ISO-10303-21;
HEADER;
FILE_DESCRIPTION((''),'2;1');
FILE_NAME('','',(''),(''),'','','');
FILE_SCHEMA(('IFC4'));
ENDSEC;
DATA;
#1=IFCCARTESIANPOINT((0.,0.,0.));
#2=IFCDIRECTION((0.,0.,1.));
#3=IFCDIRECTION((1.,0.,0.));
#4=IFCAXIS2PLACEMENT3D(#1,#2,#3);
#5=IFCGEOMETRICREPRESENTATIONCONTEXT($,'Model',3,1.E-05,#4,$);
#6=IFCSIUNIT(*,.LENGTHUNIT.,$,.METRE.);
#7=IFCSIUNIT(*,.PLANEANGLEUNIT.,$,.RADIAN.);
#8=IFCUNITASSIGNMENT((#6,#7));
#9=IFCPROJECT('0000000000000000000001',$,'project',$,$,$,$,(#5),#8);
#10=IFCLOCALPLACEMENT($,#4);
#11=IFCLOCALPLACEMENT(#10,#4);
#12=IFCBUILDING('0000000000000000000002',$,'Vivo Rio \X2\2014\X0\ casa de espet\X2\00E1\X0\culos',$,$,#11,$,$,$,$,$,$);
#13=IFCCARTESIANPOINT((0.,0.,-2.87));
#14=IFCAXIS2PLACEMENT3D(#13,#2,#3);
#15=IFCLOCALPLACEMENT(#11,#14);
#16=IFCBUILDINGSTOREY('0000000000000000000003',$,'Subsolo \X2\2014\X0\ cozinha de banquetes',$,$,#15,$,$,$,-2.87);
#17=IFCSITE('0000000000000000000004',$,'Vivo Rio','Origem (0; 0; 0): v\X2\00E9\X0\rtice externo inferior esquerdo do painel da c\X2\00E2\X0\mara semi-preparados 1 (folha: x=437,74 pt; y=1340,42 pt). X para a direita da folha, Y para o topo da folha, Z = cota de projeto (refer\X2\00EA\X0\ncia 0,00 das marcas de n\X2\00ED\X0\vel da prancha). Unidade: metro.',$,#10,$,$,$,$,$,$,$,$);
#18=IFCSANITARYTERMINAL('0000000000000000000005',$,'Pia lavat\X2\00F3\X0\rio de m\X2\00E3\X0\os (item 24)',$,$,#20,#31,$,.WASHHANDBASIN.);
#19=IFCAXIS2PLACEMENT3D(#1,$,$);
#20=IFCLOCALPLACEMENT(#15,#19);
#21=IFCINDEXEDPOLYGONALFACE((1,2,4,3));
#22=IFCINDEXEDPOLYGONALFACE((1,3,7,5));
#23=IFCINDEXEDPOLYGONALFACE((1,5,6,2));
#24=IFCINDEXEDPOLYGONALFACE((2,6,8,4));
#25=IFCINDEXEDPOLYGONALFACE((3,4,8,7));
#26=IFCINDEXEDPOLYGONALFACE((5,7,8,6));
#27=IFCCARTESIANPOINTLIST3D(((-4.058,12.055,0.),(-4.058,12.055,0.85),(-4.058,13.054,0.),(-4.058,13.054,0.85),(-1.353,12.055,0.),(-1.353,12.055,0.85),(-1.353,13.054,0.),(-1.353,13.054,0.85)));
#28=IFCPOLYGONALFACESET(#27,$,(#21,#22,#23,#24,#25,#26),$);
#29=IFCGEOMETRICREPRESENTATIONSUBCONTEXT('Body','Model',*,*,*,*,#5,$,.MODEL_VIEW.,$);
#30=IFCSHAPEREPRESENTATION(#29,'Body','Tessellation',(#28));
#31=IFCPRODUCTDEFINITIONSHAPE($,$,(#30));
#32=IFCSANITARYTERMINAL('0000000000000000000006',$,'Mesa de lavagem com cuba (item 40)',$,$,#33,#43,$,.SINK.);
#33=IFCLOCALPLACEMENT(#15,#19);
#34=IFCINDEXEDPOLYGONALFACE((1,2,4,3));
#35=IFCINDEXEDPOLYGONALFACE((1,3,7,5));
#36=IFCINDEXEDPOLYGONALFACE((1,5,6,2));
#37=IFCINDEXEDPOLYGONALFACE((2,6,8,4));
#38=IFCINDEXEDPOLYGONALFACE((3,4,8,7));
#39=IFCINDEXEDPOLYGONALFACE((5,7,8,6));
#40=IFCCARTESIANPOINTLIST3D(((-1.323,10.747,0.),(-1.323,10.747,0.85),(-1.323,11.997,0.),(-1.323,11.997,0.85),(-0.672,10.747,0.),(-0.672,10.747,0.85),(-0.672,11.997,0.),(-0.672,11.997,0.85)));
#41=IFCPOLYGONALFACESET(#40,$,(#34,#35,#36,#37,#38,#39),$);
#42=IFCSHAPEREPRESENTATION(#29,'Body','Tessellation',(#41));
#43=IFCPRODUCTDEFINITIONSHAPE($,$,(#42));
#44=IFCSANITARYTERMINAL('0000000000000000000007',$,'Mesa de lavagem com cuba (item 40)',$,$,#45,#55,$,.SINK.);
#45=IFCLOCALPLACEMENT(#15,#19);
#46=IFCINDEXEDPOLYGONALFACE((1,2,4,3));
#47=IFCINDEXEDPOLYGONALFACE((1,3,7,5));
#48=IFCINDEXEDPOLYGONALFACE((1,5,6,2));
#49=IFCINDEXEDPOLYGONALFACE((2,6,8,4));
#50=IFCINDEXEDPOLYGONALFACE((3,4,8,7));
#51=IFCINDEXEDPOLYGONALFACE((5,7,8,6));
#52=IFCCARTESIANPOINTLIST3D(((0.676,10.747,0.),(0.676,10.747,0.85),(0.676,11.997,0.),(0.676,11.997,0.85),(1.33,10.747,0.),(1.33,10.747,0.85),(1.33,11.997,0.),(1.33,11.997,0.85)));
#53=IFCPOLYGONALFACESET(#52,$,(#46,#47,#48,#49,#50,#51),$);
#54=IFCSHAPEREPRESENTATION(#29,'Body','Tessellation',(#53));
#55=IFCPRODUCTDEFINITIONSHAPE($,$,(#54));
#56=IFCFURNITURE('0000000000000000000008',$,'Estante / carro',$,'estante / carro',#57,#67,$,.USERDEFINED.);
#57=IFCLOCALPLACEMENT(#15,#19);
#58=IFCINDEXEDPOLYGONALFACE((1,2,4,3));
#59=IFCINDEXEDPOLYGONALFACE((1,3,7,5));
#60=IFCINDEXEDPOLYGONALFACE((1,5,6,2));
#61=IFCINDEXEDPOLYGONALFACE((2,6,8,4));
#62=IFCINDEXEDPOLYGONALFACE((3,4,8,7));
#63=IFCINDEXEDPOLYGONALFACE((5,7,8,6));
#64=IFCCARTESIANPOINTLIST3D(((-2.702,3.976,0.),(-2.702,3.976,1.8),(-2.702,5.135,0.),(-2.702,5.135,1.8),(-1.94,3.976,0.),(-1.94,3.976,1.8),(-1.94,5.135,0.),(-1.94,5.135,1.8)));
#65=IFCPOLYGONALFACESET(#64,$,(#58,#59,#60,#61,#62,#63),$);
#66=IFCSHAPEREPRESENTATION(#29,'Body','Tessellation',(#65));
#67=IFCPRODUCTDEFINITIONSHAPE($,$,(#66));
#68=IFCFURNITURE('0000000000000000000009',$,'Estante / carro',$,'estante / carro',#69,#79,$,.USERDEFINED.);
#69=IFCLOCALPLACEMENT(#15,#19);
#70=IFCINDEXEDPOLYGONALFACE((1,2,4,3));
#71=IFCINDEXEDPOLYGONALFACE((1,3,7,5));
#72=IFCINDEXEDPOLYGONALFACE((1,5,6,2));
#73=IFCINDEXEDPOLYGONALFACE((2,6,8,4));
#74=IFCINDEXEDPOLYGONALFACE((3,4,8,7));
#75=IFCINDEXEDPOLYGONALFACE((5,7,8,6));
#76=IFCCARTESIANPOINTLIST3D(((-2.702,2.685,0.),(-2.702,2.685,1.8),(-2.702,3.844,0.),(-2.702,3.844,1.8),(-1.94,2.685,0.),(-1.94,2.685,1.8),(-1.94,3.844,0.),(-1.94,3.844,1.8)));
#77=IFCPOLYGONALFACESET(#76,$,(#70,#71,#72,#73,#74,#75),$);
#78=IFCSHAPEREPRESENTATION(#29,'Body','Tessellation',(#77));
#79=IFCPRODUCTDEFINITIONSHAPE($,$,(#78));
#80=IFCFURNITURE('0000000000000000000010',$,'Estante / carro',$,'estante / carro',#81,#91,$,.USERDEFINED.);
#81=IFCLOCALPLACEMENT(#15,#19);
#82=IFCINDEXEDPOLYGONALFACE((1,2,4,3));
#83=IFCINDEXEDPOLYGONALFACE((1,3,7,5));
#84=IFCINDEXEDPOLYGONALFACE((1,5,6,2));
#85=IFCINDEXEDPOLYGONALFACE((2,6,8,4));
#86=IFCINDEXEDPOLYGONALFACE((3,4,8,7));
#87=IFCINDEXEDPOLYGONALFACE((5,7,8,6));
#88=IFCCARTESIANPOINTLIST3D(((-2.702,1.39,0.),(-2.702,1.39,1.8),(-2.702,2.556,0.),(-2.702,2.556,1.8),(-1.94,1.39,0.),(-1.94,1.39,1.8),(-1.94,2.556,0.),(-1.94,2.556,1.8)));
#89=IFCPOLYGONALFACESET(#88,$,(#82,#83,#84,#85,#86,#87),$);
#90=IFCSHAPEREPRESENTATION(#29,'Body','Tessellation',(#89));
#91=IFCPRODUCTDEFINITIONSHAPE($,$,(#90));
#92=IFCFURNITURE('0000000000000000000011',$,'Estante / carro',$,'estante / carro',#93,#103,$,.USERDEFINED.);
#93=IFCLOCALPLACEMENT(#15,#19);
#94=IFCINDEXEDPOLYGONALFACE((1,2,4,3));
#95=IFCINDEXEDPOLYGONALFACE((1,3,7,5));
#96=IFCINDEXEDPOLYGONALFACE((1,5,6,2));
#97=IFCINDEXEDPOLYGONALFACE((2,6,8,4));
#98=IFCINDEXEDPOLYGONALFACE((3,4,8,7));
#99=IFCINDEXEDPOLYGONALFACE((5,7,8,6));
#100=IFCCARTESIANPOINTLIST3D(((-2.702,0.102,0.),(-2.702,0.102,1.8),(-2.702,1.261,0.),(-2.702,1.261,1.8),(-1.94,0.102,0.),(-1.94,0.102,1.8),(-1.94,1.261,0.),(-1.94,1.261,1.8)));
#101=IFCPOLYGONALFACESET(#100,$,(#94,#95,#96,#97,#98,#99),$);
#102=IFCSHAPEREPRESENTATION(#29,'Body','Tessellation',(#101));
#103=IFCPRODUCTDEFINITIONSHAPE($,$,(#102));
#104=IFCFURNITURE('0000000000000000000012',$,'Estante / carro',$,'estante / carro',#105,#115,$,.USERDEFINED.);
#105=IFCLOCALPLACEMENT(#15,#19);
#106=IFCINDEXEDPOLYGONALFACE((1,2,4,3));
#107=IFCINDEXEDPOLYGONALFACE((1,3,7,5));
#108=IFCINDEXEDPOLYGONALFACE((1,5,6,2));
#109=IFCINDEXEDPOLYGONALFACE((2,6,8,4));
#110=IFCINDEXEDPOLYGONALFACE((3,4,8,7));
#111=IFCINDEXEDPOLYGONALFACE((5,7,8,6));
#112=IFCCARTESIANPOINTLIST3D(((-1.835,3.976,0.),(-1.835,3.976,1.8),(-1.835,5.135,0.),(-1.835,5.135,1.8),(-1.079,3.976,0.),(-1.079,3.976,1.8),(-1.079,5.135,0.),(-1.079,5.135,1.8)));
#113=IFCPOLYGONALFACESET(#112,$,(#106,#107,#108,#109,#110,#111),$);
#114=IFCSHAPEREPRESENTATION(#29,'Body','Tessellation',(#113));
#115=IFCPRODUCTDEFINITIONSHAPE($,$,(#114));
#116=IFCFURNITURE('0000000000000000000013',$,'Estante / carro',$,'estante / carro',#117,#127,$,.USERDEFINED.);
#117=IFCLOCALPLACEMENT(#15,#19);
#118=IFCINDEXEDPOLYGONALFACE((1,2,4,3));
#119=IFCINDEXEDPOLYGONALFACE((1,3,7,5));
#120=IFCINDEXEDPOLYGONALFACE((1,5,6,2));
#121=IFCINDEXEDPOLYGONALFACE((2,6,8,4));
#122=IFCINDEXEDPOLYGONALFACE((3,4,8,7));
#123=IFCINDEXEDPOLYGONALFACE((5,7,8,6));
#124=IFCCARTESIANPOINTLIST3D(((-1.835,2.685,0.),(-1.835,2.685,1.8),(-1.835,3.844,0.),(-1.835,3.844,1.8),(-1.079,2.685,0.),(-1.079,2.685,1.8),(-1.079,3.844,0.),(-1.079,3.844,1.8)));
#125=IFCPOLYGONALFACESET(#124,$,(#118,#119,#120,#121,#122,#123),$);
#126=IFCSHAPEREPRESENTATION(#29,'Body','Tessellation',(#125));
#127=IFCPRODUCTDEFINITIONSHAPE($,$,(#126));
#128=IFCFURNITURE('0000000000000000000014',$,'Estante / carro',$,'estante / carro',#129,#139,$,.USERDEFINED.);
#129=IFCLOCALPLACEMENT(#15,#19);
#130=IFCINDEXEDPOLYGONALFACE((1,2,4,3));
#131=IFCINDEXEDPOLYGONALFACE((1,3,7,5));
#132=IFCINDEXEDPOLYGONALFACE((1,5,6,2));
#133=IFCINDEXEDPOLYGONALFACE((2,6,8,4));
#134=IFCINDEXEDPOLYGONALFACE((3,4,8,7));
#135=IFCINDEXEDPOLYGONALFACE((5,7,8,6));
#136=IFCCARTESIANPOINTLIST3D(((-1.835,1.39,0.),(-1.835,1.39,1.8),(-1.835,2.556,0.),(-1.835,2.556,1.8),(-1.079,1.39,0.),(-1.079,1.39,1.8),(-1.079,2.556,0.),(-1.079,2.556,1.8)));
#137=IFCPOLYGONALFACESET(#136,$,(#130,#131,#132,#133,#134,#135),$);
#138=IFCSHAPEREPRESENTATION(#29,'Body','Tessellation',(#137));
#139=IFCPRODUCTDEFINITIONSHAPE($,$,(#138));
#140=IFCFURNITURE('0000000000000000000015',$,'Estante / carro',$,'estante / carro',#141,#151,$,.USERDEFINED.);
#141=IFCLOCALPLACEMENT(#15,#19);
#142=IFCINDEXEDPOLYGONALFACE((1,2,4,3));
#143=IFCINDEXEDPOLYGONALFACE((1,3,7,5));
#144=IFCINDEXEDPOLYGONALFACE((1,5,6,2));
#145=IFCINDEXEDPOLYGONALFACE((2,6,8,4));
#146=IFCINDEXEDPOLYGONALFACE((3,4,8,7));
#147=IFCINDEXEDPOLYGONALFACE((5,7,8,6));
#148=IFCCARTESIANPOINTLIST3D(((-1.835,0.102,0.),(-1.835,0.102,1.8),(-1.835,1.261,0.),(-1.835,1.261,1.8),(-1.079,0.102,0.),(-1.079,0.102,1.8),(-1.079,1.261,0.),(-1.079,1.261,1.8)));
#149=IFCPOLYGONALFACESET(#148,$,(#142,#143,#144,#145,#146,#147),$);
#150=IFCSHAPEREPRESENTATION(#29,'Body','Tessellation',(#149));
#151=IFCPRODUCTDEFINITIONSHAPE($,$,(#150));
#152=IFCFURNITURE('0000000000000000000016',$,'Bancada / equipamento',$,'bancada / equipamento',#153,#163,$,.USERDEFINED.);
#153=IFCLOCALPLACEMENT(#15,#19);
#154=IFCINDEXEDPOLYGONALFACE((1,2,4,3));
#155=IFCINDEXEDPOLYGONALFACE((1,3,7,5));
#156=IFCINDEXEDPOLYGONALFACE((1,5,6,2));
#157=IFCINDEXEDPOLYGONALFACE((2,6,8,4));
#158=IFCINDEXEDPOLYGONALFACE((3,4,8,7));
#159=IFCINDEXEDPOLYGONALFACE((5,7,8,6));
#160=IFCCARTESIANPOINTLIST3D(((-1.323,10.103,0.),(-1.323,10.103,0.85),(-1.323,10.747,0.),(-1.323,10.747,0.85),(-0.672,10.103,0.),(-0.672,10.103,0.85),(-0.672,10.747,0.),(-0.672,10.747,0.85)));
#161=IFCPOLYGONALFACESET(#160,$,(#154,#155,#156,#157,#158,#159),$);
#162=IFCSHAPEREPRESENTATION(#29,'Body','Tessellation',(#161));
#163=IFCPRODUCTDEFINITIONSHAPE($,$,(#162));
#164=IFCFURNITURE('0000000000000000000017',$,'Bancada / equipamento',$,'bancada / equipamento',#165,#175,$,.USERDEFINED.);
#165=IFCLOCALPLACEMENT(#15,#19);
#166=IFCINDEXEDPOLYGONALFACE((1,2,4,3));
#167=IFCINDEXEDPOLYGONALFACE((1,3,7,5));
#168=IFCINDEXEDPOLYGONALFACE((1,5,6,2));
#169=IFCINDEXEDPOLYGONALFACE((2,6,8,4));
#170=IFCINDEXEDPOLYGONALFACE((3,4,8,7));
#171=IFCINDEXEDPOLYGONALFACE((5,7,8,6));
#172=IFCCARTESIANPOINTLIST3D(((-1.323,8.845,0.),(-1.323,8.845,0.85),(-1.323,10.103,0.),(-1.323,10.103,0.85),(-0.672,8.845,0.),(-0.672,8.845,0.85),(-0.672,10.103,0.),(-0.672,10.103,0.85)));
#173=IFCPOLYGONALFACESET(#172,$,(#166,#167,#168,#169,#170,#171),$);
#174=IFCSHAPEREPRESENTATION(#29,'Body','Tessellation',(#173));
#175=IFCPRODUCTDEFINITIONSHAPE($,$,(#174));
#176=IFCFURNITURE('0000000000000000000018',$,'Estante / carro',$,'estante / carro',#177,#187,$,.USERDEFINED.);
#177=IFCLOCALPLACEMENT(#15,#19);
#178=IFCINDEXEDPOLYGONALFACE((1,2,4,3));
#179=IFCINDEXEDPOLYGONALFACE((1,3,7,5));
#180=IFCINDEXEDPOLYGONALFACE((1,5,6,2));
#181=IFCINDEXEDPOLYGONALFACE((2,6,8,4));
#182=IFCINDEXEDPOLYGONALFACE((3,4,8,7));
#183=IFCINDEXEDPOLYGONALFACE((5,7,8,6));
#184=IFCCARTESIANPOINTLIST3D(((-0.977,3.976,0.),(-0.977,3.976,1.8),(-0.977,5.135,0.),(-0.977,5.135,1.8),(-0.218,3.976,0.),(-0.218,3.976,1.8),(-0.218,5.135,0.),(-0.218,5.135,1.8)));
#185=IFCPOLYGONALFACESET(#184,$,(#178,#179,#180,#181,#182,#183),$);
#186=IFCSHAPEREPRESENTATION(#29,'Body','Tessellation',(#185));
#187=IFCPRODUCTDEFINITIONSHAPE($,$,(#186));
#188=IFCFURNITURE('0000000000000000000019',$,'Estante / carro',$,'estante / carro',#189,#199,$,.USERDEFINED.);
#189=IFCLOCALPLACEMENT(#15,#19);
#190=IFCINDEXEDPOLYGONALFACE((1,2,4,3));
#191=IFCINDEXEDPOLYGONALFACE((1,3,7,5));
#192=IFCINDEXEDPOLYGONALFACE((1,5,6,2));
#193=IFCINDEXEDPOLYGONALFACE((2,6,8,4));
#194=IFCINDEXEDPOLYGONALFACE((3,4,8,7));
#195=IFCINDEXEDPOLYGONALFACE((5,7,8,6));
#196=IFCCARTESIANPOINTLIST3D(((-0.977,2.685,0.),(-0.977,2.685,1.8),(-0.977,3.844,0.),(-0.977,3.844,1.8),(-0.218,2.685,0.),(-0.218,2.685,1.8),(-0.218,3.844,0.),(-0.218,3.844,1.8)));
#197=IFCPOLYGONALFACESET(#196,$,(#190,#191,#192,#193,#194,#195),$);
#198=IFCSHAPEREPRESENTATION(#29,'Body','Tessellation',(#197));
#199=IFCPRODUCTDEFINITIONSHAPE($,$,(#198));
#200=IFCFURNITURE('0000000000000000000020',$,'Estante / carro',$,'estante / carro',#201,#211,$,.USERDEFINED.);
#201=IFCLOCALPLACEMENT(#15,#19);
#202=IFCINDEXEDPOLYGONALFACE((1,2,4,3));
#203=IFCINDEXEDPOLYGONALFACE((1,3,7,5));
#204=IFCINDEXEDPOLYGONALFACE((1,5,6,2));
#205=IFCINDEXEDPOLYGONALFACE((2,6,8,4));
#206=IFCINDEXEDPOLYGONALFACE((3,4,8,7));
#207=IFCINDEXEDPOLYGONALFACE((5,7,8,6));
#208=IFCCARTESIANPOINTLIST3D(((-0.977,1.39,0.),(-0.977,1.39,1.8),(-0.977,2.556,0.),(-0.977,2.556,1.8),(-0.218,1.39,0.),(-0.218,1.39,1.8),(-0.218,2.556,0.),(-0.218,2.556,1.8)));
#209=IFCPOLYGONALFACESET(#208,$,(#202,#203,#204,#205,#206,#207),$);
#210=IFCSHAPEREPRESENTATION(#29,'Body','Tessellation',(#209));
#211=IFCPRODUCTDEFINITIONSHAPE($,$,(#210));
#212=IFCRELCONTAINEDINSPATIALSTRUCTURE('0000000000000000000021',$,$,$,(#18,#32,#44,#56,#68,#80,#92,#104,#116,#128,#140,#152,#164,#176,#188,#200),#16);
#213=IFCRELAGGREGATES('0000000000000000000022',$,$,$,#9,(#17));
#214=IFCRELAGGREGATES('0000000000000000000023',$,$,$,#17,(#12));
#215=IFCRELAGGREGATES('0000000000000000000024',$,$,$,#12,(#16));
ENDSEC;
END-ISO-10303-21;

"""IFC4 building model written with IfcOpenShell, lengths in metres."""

from ifc_helpers import new_model, si_unit, frame, origin_with_axes, origin_2d, place, context, subcontext, project, spatial, rectangle, extrude, element, save


model = new_model("IFC4")

# Units and contexts
model_context = context("Model", 3, precision=1e-05, world=origin_with_axes())
body_context = subcontext(model_context, "Body", "Model", "MODEL_VIEW")
ifc_project = project(units=[si_unit("LENGTHUNIT", "METRE"), si_unit("PLANEANGLEUNIT", "RADIAN")], contexts=[model_context])

# Site, building, storey
site_placement = place(None, origin_with_axes())
site = spatial("IfcSite", under=ifc_project, at=site_placement, Name="Vivo Rio", Description="Origem (0; 0; 0): vértice externo inferior esquerdo do painel da câmara semi-preparados 1 (folha: x=437,74 pt; y=1340,42 pt). X para a direita da folha, Y para o topo da folha, Z = cota de projeto (referência 0,00 das marcas de nível da prancha). Unidade: metro.")
building_placement = place(site_placement, origin_with_axes())
building = spatial("IfcBuilding", under=site, at=building_placement, Name="Vivo Rio — casa de espetáculos")
storey_placement = place(building_placement, frame((0.0, 0.0, -2.87), z_axis=(0.0, 0.0, 1.0), x_axis=(1.0, 0.0, 0.0)))
storey = spatial("IfcBuildingStorey", under=building, at=storey_placement, Name="Subsolo — cozinha de banquetes", Elevation=-2.87)

# Sanitary terminals
sanitary_terminal_1_placement = place(storey_placement, origin_with_axes())
element("IfcSanitaryTerminal", 1, at=sanitary_terminal_1_placement, inside=storey, Name="Pia lavatório de mãos (item 24)", PredefinedType="WASHHANDBASIN", context=body_context, shape_type="SweptSolid", body=[
    extrude(rectangle(XDim=2.705, YDim=0.999, at=origin_2d()), frame((-2.7055, 12.5545, 0.0), z_axis=(0.0, 0.0, 1.0), x_axis=(1.0, 0.0, 0.0)), (0.0, 0.0, 1.0), 0.85),
])
sanitary_terminal_2_placement = place(storey_placement, origin_with_axes())
element("IfcSanitaryTerminal", 2, at=sanitary_terminal_2_placement, inside=storey, Name="Mesa de lavagem com cuba (item 40)", PredefinedType="SINK", context=body_context, shape_type="SweptSolid", body=[
    extrude(rectangle(XDim=0.651, YDim=1.25, at=origin_2d()), frame((-0.9975, 11.372, 0.0), z_axis=(0.0, 0.0, 1.0), x_axis=(1.0, 0.0, 0.0)), (0.0, 0.0, 1.0), 0.85),
])
sanitary_terminal_3_placement = place(storey_placement, origin_with_axes())
element("IfcSanitaryTerminal", 3, at=sanitary_terminal_3_placement, inside=storey, Name="Mesa de lavagem com cuba (item 40)", PredefinedType="SINK", context=body_context, shape_type="SweptSolid", body=[
    extrude(rectangle(XDim=0.654, YDim=1.25, at=origin_2d()), frame((1.003, 11.372, 0.0), z_axis=(0.0, 0.0, 1.0), x_axis=(1.0, 0.0, 0.0)), (0.0, 0.0, 1.0), 0.85),
])

# Furniture
furniture_1_placement = place(storey_placement, origin_with_axes())
element("IfcFurniture", 4, at=furniture_1_placement, inside=storey, Name="Estante / carro", ObjectType="estante / carro", PredefinedType="USERDEFINED", context=body_context, shape_type="SweptSolid", body=[
    extrude(rectangle(XDim=0.762, YDim=1.159, at=origin_2d()), frame((-2.321, 4.5555, 0.0), z_axis=(0.0, 0.0, 1.0), x_axis=(1.0, 0.0, 0.0)), (0.0, 0.0, 1.0), 1.8),
])
furniture_2_placement = place(storey_placement, origin_with_axes())
element("IfcFurniture", 5, at=furniture_2_placement, inside=storey, Name="Estante / carro", ObjectType="estante / carro", PredefinedType="USERDEFINED", context=body_context, shape_type="SweptSolid", body=[
    extrude(rectangle(XDim=0.762, YDim=1.159, at=origin_2d()), frame((-2.321, 3.2645, 0.0), z_axis=(0.0, 0.0, 1.0), x_axis=(1.0, 0.0, 0.0)), (0.0, 0.0, 1.0), 1.8),
])
furniture_3_placement = place(storey_placement, origin_with_axes())
element("IfcFurniture", 6, at=furniture_3_placement, inside=storey, Name="Estante / carro", ObjectType="estante / carro", PredefinedType="USERDEFINED", context=body_context, shape_type="SweptSolid", body=[
    extrude(rectangle(XDim=0.762, YDim=1.166, at=origin_2d()), frame((-2.321, 1.973, 0.0), z_axis=(0.0, 0.0, 1.0), x_axis=(1.0, 0.0, 0.0)), (0.0, 0.0, 1.0), 1.8),
])
furniture_4_placement = place(storey_placement, origin_with_axes())
element("IfcFurniture", 7, at=furniture_4_placement, inside=storey, Name="Estante / carro", ObjectType="estante / carro", PredefinedType="USERDEFINED", context=body_context, shape_type="SweptSolid", body=[
    extrude(rectangle(XDim=0.762, YDim=1.159, at=origin_2d()), frame((-2.321, 0.6815, 0.0), z_axis=(0.0, 0.0, 1.0), x_axis=(1.0, 0.0, 0.0)), (0.0, 0.0, 1.0), 1.8),
])
furniture_5_placement = place(storey_placement, origin_with_axes())
element("IfcFurniture", 8, at=furniture_5_placement, inside=storey, Name="Estante / carro", ObjectType="estante / carro", PredefinedType="USERDEFINED", context=body_context, shape_type="SweptSolid", body=[
    extrude(rectangle(XDim=0.756, YDim=1.159, at=origin_2d()), frame((-1.457, 4.5555, 0.0), z_axis=(0.0, 0.0, 1.0), x_axis=(1.0, 0.0, 0.0)), (0.0, 0.0, 1.0), 1.8),
])
furniture_6_placement = place(storey_placement, origin_with_axes())
element("IfcFurniture", 9, at=furniture_6_placement, inside=storey, Name="Estante / carro", ObjectType="estante / carro", PredefinedType="USERDEFINED", context=body_context, shape_type="SweptSolid", body=[
    extrude(rectangle(XDim=0.756, YDim=1.159, at=origin_2d()), frame((-1.457, 3.2645, 0.0), z_axis=(0.0, 0.0, 1.0), x_axis=(1.0, 0.0, 0.0)), (0.0, 0.0, 1.0), 1.8),
])
furniture_7_placement = place(storey_placement, origin_with_axes())
element("IfcFurniture", 10, at=furniture_7_placement, inside=storey, Name="Estante / carro", ObjectType="estante / carro", PredefinedType="USERDEFINED", context=body_context, shape_type="SweptSolid", body=[
    extrude(rectangle(XDim=0.756, YDim=1.166, at=origin_2d()), frame((-1.457, 1.973, 0.0), z_axis=(0.0, 0.0, 1.0), x_axis=(1.0, 0.0, 0.0)), (0.0, 0.0, 1.0), 1.8),
])
furniture_8_placement = place(storey_placement, origin_with_axes())
element("IfcFurniture", 11, at=furniture_8_placement, inside=storey, Name="Estante / carro", ObjectType="estante / carro", PredefinedType="USERDEFINED", context=body_context, shape_type="SweptSolid", body=[
    extrude(rectangle(XDim=0.756, YDim=1.159, at=origin_2d()), frame((-1.457, 0.6815, 0.0), z_axis=(0.0, 0.0, 1.0), x_axis=(1.0, 0.0, 0.0)), (0.0, 0.0, 1.0), 1.8),
])
furniture_9_placement = place(storey_placement, origin_with_axes())
element("IfcFurniture", 12, at=furniture_9_placement, inside=storey, Name="Bancada / equipamento", ObjectType="bancada / equipamento", PredefinedType="USERDEFINED", context=body_context, shape_type="SweptSolid", body=[
    extrude(rectangle(XDim=0.651, YDim=0.644, at=origin_2d()), frame((-0.9975, 10.425, 0.0), z_axis=(0.0, 0.0, 1.0), x_axis=(1.0, 0.0, 0.0)), (0.0, 0.0, 1.0), 0.85),
])
furniture_10_placement = place(storey_placement, origin_with_axes())
element("IfcFurniture", 13, at=furniture_10_placement, inside=storey, Name="Bancada / equipamento", ObjectType="bancada / equipamento", PredefinedType="USERDEFINED", context=body_context, shape_type="SweptSolid", body=[
    extrude(rectangle(XDim=0.651, YDim=1.258, at=origin_2d()), frame((-0.9975, 9.474, 0.0), z_axis=(0.0, 0.0, 1.0), x_axis=(1.0, 0.0, 0.0)), (0.0, 0.0, 1.0), 0.85),
])
furniture_11_placement = place(storey_placement, origin_with_axes())
element("IfcFurniture", 14, at=furniture_11_placement, inside=storey, Name="Estante / carro", ObjectType="estante / carro", PredefinedType="USERDEFINED", context=body_context, shape_type="SweptSolid", body=[
    extrude(rectangle(XDim=0.759, YDim=1.159, at=origin_2d()), frame((-0.5975, 4.5555, 0.0), z_axis=(0.0, 0.0, 1.0), x_axis=(1.0, 0.0, 0.0)), (0.0, 0.0, 1.0), 1.8),
])
furniture_12_placement = place(storey_placement, origin_with_axes())
element("IfcFurniture", 15, at=furniture_12_placement, inside=storey, Name="Estante / carro", ObjectType="estante / carro", PredefinedType="USERDEFINED", context=body_context, shape_type="SweptSolid", body=[
    extrude(rectangle(XDim=0.759, YDim=1.159, at=origin_2d()), frame((-0.5975, 3.2645, 0.0), z_axis=(0.0, 0.0, 1.0), x_axis=(1.0, 0.0, 0.0)), (0.0, 0.0, 1.0), 1.8),
])
furniture_13_placement = place(storey_placement, origin_with_axes())
element("IfcFurniture", 16, at=furniture_13_placement, inside=storey, Name="Estante / carro", ObjectType="estante / carro", PredefinedType="USERDEFINED", context=body_context, shape_type="SweptSolid", body=[
    extrude(rectangle(XDim=0.759, YDim=1.166, at=origin_2d()), frame((-0.5975, 1.973, 0.0), z_axis=(0.0, 0.0, 1.0), x_axis=(1.0, 0.0, 0.0)), (0.0, 0.0, 1.0), 1.8),
])

save(model, "model.ifc")
